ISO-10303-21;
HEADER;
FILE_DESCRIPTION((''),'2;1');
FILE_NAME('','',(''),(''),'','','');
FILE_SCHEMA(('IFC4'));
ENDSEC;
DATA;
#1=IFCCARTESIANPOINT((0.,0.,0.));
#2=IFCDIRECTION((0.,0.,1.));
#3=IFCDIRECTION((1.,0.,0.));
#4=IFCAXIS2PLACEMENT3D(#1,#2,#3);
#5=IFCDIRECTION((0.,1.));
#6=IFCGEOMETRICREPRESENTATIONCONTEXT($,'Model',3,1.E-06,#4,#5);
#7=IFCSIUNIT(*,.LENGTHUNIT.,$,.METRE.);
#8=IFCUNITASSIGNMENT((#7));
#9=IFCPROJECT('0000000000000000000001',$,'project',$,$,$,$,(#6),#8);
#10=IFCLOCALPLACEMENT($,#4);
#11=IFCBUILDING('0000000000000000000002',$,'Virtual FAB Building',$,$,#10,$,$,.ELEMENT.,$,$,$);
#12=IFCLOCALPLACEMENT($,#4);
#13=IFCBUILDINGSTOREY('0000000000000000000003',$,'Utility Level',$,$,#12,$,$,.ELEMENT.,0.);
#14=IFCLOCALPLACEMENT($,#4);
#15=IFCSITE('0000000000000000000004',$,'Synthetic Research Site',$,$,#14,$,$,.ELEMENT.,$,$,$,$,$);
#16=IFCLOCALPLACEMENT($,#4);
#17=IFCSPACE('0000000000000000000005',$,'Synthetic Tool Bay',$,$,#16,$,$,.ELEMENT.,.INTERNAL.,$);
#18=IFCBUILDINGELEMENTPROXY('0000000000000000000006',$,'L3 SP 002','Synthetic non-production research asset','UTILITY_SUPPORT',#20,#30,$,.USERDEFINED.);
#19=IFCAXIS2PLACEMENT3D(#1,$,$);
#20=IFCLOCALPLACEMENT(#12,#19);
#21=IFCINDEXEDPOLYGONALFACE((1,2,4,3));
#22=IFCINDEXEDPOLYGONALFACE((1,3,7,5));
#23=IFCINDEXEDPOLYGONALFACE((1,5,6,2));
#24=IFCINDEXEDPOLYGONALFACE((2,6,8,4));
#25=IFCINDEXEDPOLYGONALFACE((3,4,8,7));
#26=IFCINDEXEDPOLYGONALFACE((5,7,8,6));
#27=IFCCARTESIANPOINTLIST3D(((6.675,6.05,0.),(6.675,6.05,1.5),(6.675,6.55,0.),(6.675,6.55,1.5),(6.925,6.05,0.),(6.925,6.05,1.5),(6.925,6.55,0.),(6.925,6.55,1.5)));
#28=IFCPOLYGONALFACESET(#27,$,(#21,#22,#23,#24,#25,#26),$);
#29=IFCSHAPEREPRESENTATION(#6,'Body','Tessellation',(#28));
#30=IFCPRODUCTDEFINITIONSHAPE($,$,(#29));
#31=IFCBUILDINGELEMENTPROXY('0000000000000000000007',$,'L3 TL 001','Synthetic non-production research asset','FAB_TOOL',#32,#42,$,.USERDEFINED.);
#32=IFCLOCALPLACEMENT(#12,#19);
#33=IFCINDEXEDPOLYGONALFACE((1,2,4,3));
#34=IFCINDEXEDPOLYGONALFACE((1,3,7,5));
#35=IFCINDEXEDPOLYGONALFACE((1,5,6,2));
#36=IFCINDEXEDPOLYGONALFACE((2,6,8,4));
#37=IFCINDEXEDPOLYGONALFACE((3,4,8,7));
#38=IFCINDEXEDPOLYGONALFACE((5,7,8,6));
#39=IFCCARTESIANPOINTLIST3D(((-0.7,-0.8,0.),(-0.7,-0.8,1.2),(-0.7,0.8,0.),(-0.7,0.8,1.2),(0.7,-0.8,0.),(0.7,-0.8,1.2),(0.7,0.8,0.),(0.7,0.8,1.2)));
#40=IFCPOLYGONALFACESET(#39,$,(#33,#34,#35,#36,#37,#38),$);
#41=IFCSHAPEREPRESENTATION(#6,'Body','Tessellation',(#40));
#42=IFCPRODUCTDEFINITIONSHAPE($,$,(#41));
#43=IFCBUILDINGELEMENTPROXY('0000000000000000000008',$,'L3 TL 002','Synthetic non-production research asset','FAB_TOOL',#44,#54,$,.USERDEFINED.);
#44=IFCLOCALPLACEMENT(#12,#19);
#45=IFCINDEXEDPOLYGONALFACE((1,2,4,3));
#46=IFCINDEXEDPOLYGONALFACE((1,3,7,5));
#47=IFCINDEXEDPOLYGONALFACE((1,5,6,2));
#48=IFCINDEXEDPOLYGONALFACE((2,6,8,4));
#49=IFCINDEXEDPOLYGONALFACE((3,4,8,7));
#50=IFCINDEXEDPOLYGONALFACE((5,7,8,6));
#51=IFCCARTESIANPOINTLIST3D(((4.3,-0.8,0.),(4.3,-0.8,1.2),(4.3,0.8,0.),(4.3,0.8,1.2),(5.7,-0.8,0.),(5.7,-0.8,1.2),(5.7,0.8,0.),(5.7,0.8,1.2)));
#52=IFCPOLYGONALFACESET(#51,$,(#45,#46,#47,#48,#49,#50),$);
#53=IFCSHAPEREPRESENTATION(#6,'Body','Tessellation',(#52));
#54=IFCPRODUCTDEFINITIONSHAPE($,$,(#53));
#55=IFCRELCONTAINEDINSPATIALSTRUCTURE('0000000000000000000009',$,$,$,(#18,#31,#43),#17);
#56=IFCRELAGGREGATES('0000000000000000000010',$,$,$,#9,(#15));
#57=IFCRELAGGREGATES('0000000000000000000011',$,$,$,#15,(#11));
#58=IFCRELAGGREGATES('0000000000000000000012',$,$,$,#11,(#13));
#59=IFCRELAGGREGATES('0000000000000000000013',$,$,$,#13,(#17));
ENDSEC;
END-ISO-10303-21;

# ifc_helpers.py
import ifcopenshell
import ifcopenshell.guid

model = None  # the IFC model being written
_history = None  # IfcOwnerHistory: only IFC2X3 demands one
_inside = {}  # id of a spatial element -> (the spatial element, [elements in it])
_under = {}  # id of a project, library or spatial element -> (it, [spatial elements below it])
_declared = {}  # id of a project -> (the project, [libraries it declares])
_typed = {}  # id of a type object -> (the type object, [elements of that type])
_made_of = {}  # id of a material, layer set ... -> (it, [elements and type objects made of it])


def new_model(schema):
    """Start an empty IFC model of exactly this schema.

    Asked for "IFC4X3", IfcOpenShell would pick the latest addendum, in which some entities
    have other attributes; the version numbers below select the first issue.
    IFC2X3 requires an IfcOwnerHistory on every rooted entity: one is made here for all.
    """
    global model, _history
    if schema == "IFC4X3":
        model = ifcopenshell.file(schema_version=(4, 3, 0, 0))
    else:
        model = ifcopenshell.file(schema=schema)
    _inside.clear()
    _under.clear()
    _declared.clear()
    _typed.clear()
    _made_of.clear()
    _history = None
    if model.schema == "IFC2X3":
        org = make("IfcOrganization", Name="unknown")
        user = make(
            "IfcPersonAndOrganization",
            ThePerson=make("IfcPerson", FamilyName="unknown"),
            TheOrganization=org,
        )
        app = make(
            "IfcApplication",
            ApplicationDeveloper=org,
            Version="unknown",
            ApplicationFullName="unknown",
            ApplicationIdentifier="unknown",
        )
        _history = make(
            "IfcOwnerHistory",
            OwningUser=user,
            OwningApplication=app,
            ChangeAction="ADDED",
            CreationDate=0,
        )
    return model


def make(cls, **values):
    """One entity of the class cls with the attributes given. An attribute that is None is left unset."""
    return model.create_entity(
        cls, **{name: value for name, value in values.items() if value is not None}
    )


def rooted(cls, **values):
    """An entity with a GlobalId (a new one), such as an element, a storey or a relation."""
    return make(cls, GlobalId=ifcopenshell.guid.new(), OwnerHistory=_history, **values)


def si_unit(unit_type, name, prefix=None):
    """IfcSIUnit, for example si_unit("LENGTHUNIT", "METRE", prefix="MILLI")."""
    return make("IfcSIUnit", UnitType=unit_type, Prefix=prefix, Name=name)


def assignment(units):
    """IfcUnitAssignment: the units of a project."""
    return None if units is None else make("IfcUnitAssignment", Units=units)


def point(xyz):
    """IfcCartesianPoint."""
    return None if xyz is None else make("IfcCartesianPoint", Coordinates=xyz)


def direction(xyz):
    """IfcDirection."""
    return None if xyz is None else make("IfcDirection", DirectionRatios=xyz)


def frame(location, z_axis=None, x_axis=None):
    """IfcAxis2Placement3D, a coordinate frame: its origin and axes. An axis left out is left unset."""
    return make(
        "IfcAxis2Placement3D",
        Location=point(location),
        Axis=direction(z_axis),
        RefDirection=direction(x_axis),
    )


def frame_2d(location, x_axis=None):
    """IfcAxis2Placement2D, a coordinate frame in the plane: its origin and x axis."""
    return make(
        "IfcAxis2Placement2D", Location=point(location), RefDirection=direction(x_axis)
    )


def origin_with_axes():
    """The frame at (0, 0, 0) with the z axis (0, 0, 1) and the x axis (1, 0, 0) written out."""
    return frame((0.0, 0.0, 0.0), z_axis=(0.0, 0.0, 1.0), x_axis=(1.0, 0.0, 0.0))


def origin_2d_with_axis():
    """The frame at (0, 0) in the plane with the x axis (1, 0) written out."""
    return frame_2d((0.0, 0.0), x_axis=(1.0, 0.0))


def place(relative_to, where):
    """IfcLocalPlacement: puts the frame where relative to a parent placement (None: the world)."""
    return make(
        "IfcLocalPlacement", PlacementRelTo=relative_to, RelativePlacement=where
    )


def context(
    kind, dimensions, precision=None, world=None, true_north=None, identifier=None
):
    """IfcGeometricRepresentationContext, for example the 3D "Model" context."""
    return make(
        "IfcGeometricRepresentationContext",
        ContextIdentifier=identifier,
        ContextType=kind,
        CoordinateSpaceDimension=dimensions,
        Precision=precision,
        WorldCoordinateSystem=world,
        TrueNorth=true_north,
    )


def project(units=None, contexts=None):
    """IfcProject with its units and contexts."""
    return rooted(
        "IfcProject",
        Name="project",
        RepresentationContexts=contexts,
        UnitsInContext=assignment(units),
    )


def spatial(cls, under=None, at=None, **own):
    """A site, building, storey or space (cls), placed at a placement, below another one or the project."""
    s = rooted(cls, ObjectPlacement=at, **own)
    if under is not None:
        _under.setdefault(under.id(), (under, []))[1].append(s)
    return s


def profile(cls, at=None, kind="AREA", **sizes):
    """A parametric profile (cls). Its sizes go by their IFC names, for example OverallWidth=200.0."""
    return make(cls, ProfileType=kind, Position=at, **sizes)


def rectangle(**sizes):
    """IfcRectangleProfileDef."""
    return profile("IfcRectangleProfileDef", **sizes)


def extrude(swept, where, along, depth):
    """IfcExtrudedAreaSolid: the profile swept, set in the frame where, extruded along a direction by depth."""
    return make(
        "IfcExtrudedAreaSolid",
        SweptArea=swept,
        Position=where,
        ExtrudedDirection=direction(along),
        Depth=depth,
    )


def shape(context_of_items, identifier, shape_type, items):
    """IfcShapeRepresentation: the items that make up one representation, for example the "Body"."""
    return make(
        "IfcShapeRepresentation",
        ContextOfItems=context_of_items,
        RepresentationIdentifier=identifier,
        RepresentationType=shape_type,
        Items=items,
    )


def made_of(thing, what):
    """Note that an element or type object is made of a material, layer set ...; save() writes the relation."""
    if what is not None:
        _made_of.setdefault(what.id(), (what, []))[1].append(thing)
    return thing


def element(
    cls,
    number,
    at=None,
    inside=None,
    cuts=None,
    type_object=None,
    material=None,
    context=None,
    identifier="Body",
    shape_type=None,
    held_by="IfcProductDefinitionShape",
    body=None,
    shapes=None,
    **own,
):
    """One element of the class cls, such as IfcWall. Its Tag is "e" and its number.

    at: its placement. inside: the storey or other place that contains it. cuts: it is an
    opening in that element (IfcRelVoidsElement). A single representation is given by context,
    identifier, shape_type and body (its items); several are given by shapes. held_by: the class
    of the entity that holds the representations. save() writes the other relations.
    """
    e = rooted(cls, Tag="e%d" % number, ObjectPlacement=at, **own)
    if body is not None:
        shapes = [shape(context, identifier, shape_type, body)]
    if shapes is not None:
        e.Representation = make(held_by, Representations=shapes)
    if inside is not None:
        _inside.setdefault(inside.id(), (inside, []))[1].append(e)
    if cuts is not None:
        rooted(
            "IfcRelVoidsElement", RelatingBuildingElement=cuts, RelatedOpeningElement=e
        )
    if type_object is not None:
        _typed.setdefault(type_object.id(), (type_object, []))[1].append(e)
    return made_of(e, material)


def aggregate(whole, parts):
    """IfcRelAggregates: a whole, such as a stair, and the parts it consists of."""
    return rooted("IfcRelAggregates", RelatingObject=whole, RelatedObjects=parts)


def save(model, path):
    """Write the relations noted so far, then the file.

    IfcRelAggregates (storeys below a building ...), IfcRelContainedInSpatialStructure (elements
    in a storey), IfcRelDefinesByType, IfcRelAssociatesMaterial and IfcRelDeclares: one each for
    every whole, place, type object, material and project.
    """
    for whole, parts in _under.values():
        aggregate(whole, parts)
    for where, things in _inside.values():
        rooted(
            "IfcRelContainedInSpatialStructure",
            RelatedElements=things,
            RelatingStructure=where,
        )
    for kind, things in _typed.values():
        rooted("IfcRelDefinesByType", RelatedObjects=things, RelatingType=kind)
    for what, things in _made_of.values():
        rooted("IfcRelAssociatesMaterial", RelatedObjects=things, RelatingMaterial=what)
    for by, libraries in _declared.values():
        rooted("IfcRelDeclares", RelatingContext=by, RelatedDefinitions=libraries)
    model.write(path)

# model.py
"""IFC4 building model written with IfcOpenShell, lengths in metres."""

from ifc_helpers import new_model, si_unit, direction, frame, origin_with_axes, origin_2d_with_axis, place, context, project, spatial, rectangle, extrude, element, save


model = new_model("IFC4")

# Units and contexts
model_context = context("Model", 3, precision=1e-06, world=origin_with_axes(), true_north=direction((0.0, 1.0)))
ifc_project = project(units=[si_unit("LENGTHUNIT", "METRE")], contexts=[model_context])

# Site, building, storey, space
site_placement = place(None, origin_with_axes())
site = spatial("IfcSite", under=ifc_project, at=site_placement, Name="Synthetic Research Site", CompositionType="ELEMENT")
building_placement = place(None, origin_with_axes())
building = spatial("IfcBuilding", under=site, at=building_placement, Name="Virtual FAB Building", CompositionType="ELEMENT")
storey_placement = place(None, origin_with_axes())
storey = spatial("IfcBuildingStorey", under=building, at=storey_placement, Name="Utility Level", CompositionType="ELEMENT", Elevation=0.0)
space_placement = place(None, origin_with_axes())
space = spatial("IfcSpace", under=storey, at=space_placement, Name="Synthetic Tool Bay", CompositionType="ELEMENT", PredefinedType="INTERNAL")

# Building element proxies
proxy_placement = place(None, frame((6.8, 6.3, 0.0), z_axis=(0.0, 0.0, 1.0), x_axis=(1.0, 0.0, 0.0)))
element("IfcBuildingElementProxy", 1, at=proxy_placement, inside=space, Name="L3 SP 002", Description="Synthetic non-production research asset", ObjectType="UTILITY_SUPPORT", PredefinedType="USERDEFINED", context=model_context, shape_type="SweptSolid", body=[
    extrude(rectangle(XDim=0.25, YDim=0.5, at=origin_2d_with_axis()), origin_with_axes(), (0.0, 0.0, 1.0), 1.5),
])
for number, where, z_axis, x_axis, name in (
    (2, (0.0, 0.0, 0.0), (0.0, 0.0, 1.0), (1.0, 0.0, 0.0), "L3 TL 001"),
    (3, (5.0, 0.0, 0.0), (0.0, 0.0, 1.0), (1.0, 0.0, 0.0), "L3 TL 002"),
):
    element("IfcBuildingElementProxy", number, at=place(None, frame(where, z_axis=z_axis, x_axis=x_axis)), inside=space, Name=name, Description="Synthetic non-production research asset", ObjectType="FAB_TOOL", PredefinedType="USERDEFINED", context=model_context, shape_type="SweptSolid", body=[
        extrude(rectangle(XDim=1.4, YDim=1.6, at=origin_2d_with_axis()), origin_with_axes(), (0.0, 0.0, 1.0), 1.2),
    ])

save(model, "model.ifc")
